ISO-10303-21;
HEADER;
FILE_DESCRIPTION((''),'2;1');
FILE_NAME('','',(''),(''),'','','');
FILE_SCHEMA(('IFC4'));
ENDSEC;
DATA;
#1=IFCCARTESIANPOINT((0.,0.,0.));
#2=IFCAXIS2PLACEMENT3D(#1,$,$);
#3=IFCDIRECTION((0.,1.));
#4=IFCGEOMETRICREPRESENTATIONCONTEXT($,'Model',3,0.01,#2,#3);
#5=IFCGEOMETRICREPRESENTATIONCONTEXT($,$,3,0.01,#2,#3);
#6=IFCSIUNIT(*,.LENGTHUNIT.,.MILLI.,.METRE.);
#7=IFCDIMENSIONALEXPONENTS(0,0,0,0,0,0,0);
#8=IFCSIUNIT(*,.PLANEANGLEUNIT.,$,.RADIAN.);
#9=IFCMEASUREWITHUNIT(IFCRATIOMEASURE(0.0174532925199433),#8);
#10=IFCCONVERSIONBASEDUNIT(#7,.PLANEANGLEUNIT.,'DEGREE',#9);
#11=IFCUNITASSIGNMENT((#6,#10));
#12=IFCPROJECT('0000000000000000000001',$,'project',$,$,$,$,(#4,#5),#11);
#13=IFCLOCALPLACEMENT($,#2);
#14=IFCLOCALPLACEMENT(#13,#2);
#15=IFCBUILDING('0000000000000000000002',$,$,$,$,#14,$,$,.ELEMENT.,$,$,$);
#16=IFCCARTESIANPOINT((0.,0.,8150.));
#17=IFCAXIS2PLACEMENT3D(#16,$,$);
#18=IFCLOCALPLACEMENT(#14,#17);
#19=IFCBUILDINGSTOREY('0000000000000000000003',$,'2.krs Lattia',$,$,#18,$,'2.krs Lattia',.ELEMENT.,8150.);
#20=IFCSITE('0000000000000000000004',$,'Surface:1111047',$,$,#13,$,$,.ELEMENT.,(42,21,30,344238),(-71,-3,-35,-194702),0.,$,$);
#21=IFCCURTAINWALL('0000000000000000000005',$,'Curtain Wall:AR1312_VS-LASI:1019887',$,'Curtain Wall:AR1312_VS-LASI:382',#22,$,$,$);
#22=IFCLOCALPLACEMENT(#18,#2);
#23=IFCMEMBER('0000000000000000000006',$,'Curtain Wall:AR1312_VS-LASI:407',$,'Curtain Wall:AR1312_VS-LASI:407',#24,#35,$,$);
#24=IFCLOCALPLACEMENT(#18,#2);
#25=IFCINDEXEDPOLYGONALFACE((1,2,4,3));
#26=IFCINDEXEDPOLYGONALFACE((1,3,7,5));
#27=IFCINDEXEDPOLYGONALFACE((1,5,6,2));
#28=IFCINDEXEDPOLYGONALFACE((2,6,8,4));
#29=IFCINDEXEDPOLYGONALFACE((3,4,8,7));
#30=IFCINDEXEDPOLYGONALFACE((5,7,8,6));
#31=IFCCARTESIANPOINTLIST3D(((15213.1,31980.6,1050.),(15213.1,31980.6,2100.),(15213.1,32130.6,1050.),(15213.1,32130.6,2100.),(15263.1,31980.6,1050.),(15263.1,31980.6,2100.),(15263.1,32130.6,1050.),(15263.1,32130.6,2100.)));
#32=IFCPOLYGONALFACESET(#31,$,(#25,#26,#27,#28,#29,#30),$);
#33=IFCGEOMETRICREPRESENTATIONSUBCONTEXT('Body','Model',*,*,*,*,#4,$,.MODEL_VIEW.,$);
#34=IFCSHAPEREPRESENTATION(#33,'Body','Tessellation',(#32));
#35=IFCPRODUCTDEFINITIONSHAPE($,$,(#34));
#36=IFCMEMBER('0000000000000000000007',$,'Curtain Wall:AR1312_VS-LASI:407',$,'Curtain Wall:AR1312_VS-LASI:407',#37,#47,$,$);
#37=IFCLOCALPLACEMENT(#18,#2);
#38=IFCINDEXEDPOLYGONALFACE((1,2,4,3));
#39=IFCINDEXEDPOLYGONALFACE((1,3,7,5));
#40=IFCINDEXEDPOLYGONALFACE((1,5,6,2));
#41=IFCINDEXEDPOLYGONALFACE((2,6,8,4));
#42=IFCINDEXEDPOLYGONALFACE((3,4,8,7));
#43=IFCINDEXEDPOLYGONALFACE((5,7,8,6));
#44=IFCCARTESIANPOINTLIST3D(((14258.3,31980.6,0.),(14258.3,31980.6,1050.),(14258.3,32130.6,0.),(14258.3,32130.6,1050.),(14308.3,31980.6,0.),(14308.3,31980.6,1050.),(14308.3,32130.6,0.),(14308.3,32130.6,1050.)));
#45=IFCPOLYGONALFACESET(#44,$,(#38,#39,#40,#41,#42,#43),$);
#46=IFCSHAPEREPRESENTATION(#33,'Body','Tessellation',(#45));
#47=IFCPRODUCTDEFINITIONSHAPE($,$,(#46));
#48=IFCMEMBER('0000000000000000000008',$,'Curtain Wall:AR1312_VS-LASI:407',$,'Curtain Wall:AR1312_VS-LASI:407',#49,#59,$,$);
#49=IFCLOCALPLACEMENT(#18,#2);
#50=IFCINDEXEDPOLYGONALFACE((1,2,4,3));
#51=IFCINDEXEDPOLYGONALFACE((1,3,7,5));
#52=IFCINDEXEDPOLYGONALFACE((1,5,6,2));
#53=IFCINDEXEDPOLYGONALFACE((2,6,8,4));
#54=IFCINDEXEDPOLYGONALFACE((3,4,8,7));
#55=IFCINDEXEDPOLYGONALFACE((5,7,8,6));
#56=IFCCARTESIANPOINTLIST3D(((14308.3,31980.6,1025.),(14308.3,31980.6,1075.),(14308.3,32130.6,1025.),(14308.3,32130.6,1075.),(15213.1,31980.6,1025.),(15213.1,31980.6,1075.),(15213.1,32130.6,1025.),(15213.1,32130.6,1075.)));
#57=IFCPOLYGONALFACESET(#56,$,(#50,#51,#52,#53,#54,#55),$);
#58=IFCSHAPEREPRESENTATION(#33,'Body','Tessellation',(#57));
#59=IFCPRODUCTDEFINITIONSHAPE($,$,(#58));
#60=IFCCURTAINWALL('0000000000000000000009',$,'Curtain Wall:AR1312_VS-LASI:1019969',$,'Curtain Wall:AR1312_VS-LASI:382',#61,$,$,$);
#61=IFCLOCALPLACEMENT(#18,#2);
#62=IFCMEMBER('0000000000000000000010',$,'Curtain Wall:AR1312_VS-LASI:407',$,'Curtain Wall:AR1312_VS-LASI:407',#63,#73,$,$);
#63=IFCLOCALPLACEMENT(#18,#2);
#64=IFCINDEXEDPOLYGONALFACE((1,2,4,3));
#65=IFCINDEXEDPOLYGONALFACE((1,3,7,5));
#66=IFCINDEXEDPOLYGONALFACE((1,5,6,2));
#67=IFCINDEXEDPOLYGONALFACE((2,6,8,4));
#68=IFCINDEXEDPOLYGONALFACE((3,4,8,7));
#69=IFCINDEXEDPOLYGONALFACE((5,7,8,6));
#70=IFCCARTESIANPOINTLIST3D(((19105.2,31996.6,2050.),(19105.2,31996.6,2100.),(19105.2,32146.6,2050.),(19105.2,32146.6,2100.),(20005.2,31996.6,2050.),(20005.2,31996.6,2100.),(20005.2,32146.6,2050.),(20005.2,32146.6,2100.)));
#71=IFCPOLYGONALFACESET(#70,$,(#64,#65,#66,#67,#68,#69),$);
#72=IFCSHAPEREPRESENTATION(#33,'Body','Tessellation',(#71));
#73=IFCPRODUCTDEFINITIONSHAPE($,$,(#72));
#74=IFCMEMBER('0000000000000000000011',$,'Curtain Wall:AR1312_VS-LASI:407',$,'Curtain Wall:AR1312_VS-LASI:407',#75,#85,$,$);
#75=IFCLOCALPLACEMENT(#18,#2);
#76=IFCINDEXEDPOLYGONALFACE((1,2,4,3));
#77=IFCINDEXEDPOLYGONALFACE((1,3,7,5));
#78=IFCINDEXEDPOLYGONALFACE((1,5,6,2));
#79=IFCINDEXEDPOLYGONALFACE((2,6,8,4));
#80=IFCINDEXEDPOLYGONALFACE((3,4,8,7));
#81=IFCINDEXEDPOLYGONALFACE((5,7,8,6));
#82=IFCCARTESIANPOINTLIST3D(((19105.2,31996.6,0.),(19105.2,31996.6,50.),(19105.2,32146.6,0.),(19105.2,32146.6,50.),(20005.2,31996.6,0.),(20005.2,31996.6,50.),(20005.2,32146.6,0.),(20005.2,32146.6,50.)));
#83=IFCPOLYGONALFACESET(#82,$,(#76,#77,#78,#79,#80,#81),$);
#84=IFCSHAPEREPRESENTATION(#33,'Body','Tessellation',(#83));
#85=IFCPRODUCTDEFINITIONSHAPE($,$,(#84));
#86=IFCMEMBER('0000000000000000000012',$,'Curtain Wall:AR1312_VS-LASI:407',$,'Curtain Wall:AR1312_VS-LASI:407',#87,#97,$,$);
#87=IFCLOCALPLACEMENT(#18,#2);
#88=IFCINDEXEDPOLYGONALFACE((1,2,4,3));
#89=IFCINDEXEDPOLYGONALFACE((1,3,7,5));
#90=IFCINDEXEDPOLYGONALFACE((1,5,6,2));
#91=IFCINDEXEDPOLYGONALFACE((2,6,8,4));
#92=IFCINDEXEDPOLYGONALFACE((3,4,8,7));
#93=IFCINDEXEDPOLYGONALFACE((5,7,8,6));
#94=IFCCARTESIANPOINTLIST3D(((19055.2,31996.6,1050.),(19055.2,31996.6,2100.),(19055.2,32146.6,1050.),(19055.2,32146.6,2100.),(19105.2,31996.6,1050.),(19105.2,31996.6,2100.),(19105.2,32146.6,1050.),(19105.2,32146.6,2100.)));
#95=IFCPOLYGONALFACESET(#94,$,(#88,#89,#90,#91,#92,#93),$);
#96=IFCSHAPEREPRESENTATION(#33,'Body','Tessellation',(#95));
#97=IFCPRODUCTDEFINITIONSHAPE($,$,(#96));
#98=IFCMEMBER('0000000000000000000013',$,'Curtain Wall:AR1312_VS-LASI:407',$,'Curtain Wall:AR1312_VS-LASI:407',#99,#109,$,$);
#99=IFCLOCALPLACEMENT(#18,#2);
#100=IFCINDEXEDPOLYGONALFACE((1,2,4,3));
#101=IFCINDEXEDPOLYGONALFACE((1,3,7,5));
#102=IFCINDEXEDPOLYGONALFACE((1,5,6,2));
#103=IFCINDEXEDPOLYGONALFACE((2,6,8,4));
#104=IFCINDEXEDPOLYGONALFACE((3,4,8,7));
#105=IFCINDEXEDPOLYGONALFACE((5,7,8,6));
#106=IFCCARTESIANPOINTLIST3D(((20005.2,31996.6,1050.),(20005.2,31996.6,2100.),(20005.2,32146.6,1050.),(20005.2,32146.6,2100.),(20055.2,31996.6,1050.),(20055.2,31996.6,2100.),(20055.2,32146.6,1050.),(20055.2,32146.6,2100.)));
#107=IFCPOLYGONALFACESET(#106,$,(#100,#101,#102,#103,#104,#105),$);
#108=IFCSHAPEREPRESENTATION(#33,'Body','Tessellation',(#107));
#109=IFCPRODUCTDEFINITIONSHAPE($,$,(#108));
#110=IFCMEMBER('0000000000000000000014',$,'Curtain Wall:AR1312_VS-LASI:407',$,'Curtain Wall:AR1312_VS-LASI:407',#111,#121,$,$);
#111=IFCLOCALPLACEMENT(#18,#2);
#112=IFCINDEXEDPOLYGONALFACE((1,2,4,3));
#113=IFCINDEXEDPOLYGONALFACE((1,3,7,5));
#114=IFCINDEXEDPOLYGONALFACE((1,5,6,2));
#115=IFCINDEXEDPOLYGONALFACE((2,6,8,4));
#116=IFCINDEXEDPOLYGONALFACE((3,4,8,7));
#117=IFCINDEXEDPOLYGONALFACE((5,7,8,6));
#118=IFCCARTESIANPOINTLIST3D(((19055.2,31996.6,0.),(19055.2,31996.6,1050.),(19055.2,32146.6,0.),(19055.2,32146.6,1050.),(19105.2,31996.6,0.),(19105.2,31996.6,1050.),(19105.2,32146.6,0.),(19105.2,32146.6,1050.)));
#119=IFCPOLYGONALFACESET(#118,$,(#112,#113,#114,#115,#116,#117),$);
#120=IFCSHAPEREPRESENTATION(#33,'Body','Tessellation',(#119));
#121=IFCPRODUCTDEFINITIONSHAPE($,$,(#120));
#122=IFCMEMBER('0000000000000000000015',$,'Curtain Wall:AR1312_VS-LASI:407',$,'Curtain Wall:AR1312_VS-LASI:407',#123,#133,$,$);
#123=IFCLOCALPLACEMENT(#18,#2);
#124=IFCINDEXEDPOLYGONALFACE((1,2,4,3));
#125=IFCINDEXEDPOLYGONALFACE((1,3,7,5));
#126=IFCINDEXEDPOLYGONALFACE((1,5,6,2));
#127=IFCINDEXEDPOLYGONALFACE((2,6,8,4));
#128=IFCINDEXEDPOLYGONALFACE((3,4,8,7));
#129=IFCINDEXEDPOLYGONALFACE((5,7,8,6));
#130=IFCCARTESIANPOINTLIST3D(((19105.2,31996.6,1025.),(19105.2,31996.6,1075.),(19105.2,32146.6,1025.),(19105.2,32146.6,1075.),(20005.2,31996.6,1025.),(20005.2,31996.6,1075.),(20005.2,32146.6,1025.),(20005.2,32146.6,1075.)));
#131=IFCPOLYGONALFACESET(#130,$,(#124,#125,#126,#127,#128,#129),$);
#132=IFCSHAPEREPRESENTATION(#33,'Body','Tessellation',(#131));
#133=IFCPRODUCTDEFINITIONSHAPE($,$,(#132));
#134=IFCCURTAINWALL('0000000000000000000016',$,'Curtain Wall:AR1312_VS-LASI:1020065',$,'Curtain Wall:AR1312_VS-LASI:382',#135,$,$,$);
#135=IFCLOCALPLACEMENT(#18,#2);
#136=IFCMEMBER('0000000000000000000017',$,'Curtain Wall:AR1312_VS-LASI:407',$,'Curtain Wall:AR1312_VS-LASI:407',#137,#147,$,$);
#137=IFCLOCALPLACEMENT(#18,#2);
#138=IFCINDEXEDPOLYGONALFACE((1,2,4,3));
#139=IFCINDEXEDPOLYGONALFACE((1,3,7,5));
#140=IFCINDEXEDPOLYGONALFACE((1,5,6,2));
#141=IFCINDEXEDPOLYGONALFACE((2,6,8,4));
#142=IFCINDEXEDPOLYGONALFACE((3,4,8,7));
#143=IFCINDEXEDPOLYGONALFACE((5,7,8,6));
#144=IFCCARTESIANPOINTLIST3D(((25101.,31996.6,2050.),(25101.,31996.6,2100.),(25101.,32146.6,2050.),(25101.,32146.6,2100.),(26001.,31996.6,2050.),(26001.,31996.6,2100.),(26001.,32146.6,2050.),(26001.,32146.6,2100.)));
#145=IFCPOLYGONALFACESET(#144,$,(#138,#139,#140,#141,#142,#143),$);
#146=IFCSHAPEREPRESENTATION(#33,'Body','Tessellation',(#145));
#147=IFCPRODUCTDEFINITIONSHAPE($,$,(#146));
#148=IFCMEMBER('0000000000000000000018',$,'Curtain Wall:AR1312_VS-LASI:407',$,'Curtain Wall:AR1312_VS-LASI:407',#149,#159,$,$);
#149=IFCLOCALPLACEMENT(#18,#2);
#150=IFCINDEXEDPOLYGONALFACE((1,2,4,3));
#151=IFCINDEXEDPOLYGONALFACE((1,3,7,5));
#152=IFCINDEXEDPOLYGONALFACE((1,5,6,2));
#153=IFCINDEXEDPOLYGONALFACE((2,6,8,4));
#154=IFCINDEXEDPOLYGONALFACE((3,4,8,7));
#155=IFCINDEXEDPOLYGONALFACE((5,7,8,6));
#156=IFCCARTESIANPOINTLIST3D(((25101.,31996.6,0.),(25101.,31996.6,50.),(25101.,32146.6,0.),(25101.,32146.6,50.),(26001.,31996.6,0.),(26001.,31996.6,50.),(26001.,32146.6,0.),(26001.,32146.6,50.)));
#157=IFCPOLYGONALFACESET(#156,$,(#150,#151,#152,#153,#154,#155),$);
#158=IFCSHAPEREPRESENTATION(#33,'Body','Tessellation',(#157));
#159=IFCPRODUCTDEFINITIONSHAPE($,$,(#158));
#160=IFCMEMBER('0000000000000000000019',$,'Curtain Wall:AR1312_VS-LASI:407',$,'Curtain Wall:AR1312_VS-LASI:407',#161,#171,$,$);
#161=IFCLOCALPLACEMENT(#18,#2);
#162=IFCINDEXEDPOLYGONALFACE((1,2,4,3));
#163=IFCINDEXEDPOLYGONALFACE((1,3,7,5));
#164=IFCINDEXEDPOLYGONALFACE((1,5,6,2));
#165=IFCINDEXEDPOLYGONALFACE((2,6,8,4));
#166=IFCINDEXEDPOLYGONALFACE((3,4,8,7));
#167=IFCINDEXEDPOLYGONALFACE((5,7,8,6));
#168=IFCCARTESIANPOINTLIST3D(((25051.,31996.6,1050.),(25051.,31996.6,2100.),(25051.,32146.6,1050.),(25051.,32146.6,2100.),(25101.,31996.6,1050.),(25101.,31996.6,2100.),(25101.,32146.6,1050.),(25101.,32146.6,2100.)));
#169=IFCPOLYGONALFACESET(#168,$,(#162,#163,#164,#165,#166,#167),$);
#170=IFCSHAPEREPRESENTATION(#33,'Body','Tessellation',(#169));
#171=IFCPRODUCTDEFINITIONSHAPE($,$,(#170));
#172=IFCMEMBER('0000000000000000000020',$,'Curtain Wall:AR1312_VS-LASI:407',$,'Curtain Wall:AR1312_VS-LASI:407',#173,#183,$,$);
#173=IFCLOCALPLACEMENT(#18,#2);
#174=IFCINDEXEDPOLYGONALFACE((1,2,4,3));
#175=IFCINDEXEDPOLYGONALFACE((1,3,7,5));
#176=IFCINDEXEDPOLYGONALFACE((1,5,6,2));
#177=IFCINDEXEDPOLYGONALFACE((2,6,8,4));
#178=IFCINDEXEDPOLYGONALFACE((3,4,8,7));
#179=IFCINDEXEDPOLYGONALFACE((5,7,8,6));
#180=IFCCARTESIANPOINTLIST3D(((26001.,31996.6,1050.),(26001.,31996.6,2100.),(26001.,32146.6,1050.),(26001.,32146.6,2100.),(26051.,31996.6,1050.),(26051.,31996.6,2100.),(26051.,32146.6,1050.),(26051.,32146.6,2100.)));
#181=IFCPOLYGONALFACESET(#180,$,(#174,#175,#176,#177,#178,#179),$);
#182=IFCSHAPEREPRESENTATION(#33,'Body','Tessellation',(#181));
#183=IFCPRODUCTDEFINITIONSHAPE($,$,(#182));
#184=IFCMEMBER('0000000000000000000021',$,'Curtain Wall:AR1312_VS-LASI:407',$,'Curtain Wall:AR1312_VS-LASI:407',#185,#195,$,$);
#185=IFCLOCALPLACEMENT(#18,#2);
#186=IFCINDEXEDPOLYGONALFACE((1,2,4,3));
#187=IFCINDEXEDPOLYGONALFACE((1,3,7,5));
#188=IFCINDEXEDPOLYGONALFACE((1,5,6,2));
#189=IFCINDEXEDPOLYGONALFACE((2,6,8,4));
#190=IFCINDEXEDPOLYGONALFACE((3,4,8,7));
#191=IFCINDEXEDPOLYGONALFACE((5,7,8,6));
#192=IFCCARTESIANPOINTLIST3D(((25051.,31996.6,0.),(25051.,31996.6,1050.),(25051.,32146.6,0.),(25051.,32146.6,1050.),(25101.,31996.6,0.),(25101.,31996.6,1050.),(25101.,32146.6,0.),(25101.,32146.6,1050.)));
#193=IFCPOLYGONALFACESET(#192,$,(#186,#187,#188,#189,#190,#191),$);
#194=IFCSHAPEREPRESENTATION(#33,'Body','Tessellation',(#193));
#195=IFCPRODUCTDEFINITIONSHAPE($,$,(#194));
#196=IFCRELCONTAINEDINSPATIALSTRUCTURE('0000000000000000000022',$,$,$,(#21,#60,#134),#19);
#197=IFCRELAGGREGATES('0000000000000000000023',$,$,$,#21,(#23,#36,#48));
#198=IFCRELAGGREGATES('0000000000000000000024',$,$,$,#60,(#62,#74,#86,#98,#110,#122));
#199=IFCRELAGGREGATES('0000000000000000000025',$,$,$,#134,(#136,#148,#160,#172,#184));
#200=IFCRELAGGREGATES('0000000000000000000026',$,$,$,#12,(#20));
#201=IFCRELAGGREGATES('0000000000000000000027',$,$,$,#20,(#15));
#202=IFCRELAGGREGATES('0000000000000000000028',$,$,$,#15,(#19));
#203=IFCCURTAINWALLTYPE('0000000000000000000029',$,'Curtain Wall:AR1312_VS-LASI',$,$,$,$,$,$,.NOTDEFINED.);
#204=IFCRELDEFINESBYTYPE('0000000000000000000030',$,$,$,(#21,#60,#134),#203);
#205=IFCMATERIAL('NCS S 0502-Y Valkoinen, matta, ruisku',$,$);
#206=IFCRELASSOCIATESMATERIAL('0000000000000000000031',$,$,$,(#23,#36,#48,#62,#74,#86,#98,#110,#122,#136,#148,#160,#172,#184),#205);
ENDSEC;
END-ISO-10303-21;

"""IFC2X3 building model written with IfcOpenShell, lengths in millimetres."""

from ifc_helpers import new_model, entity, si_unit, converted_unit, direction, frame, frame_2d, origin, place, context, subcontext, project, spatial, rectangle, extrude, material, type_object, element, aggregate, save


model = new_model("IFC2X3")

# Units and contexts
model_context = context("Model", 3, precision=0.01, world=origin(), true_north=direction((0.0, 1.0)))
context_of_model = context(None, 3, precision=0.01, world=origin(), true_north=direction((0.0, 1.0)))
body_context = subcontext(model_context, "Body", "Model", "MODEL_VIEW")
ifc_project = project(units=[si_unit("LENGTHUNIT", "METRE", prefix="MILLI"), converted_unit("PLANEANGLEUNIT", "DEGREE", entity("IfcRatioMeasure", 0.0174532925199433), si_unit("PLANEANGLEUNIT", "RADIAN"), dimensions=[0, 0, 0, 0, 0, 0, 0])], contexts=[model_context, context_of_model])

# Site, building, storey
site_placement = place(None, origin())
site = spatial("IfcSite", under=ifc_project, at=site_placement, Name="Surface:1111047", CompositionType="ELEMENT", RefLatitude=(42, 21, 30, 344238), RefLongitude=(-71, -3, -35, -194702), RefElevation=0.0)
building_placement = place(site_placement, origin())
building = spatial("IfcBuilding", under=site, at=building_placement, CompositionType="ELEMENT")
storey_placement = place(building_placement, frame((0.0, 0.0, 8150.0)))
storey = spatial("IfcBuildingStorey", under=building, at=storey_placement, Name="2.krs Lattia", LongName="2.krs Lattia", CompositionType="ELEMENT", Elevation=8150.0)

# Curtain walls, members
curtain_wall_type = type_object("IfcCurtainWallType", Name="Curtain Wall:AR1312_VS-LASI", PredefinedType="NOTDEFINED")
curtain_wall_1_placement = place(storey_placement, frame((0.0, 0.0, -8150.0)))
curtain_wall_1 = element("IfcCurtainWall", 1, at=curtain_wall_1_placement, inside=storey, type_object=curtain_wall_type, Name="Curtain Wall:AR1312_VS-LASI:1019887", ObjectType="Curtain Wall:AR1312_VS-LASI:382")
ifc_material_1 = material(Name="NCS S 0502-Y Valkoinen, matta, ruisku")
member_1_placement = place(curtain_wall_1_placement, frame((0.0, 0.0, 8150.0)))
member_1 = element("IfcMember", 2, at=member_1_placement, material=ifc_material_1, Name="Curtain Wall:AR1312_VS-LASI:407", ObjectType="Curtain Wall:AR1312_VS-LASI:407", context=body_context, shape_type="SweptSolid", body=[
    extrude(rectangle(XDim=50.0, YDim=150.0, at=frame_2d((0.0, 0.0), x_axis=(1.0, 0.0))), frame((15238.1, 32055.6, 1050.0), z_axis=(0.0, 0.0, 1.0), x_axis=(-1.0, 0.0, 0.0)), (0.0, 0.0, 1.0), 1050.0),
])
member_2_placement = place(curtain_wall_1_placement, frame((0.0, 0.0, 8150.0)))
member_2 = element("IfcMember", 3, at=member_2_placement, material=ifc_material_1, Name="Curtain Wall:AR1312_VS-LASI:407", ObjectType="Curtain Wall:AR1312_VS-LASI:407", context=body_context, shape_type="SweptSolid", body=[
    extrude(rectangle(XDim=50.0, YDim=150.0, at=frame_2d((0.0, 0.0), x_axis=(1.0, 0.0))), frame((14283.3, 32055.6, 1050.0), z_axis=(0.0, 0.0, -1.0), x_axis=(-1.0, 0.0, 0.0)), (0.0, 0.0, 1.0), 1050.0),
])
member_3_placement = place(curtain_wall_1_placement, frame((0.0, 0.0, 8150.0)))
member_3 = element("IfcMember", 4, at=member_3_placement, material=ifc_material_1, Name="Curtain Wall:AR1312_VS-LASI:407", ObjectType="Curtain Wall:AR1312_VS-LASI:407", context=body_context, shape_type="SweptSolid", body=[
    extrude(rectangle(XDim=50.0, YDim=150.0, at=frame_2d((0.0, 0.0), x_axis=(1.0, 0.0))), frame((15213.1, 32055.6, 1050.0), z_axis=(-1.0, 0.0, 0.0), x_axis=(0.0, 0.0, -1.0)), (0.0, 0.0, 1.0), 904.8),
])
aggregate(curtain_wall_1, [member_1, member_2, member_3])
curtain_wall_2_placement = place(storey_placement, frame((0.0, 0.0, -8150.0)))
curtain_wall_2 = element("IfcCurtainWall", 5, at=curtain_wall_2_placement, inside=storey, type_object=curtain_wall_type, Name="Curtain Wall:AR1312_VS-LASI:1019969", ObjectType="Curtain Wall:AR1312_VS-LASI:382")
member_4_placement = place(curtain_wall_2_placement, frame((0.0, 0.0, 8150.0)))
member_4 = element("IfcMember", 6, at=member_4_placement, material=ifc_material_1, Name="Curtain Wall:AR1312_VS-LASI:407", ObjectType="Curtain Wall:AR1312_VS-LASI:407", context=body_context, shape_type="SweptSolid", body=[
    extrude(rectangle(XDim=50.0, YDim=150.0, at=frame_2d((0.0, 0.0), x_axis=(1.0, 0.0))), frame((20005.2, 32071.6, 2075.0), z_axis=(-1.0, 0.0, 0.0), x_axis=(0.0, 0.0, -1.0)), (0.0, 0.0, 1.0), 900.0),
])
member_5_placement = place(curtain_wall_2_placement, frame((0.0, 0.0, 8150.0)))
member_5 = element("IfcMember", 7, at=member_5_placement, material=ifc_material_1, Name="Curtain Wall:AR1312_VS-LASI:407", ObjectType="Curtain Wall:AR1312_VS-LASI:407", context=body_context, shape_type="SweptSolid", body=[
    extrude(rectangle(XDim=50.0, YDim=150.0, at=frame_2d((0.0, 0.0), x_axis=(1.0, 0.0))), frame((19105.2, 32071.6, 25.0), z_axis=(1.0, 0.0, 0.0), x_axis=(0.0, 0.0, -1.0)), (0.0, 0.0, 1.0), 900.0),
])
member_6_placement = place(curtain_wall_2_placement, frame((0.0, 0.0, 8150.0)))
member_6 = element("IfcMember", 8, at=member_6_placement, material=ifc_material_1, Name="Curtain Wall:AR1312_VS-LASI:407", ObjectType="Curtain Wall:AR1312_VS-LASI:407", context=body_context, shape_type="SweptSolid", body=[
    extrude(rectangle(XDim=50.0, YDim=150.0, at=frame_2d((0.0, 0.0), x_axis=(1.0, 0.0))), frame((19080.2, 32071.6, 2100.0), z_axis=(0.0, 0.0, -1.0), x_axis=(-1.0, 0.0, 0.0)), (0.0, 0.0, 1.0), 1050.0),
])
member_7_placement = place(curtain_wall_2_placement, frame((0.0, 0.0, 8150.0)))
member_7 = element("IfcMember", 9, at=member_7_placement, material=ifc_material_1, Name="Curtain Wall:AR1312_VS-LASI:407", ObjectType="Curtain Wall:AR1312_VS-LASI:407", context=body_context, shape_type="SweptSolid", body=[
    extrude(rectangle(XDim=50.0, YDim=150.0, at=frame_2d((0.0, 0.0), x_axis=(1.0, 0.0))), frame((20030.2, 32071.6, 1050.0), z_axis=(0.0, 0.0, 1.0), x_axis=(-1.0, 0.0, 0.0)), (0.0, 0.0, 1.0), 1050.0),
])
member_8_placement = place(curtain_wall_2_placement, frame((0.0, 0.0, 8150.0)))
member_8 = element("IfcMember", 10, at=member_8_placement, material=ifc_material_1, Name="Curtain Wall:AR1312_VS-LASI:407", ObjectType="Curtain Wall:AR1312_VS-LASI:407", context=body_context, shape_type="SweptSolid", body=[
    extrude(rectangle(XDim=50.0, YDim=150.0, at=frame_2d((0.0, 0.0), x_axis=(1.0, 0.0))), frame((19080.2, 32071.6, 1050.0), z_axis=(0.0, 0.0, -1.0), x_axis=(-1.0, 0.0, 0.0)), (0.0, 0.0, 1.0), 1050.0),
])
member_9_placement = place(curtain_wall_2_placement, frame((0.0, 0.0, 8150.0)))
member_9 = element("IfcMember", 11, at=member_9_placement, material=ifc_material_1, Name="Curtain Wall:AR1312_VS-LASI:407", ObjectType="Curtain Wall:AR1312_VS-LASI:407", context=body_context, shape_type="SweptSolid", body=[
    extrude(rectangle(XDim=50.0, YDim=150.0, at=frame_2d((0.0, 0.0), x_axis=(1.0, 0.0))), frame((20005.2, 32071.6, 1050.0), z_axis=(-1.0, 0.0, 0.0), x_axis=(0.0, 0.0, -1.0)), (0.0, 0.0, 1.0), 900.0),
])
aggregate(curtain_wall_2, [member_4, member_5, member_6, member_7, member_8, member_9])
curtain_wall_3_placement = place(storey_placement, frame((0.0, 0.0, -8150.0)))
curtain_wall_3 = element("IfcCurtainWall", 12, at=curtain_wall_3_placement, inside=storey, type_object=curtain_wall_type, Name="Curtain Wall:AR1312_VS-LASI:1020065", ObjectType="Curtain Wall:AR1312_VS-LASI:382")
member_10_placement = place(curtain_wall_3_placement, frame((0.0, 0.0, 8150.0)))
member_10 = element("IfcMember", 13, at=member_10_placement, material=ifc_material_1, Name="Curtain Wall:AR1312_VS-LASI:407", ObjectType="Curtain Wall:AR1312_VS-LASI:407", context=body_context, shape_type="SweptSolid", body=[
    extrude(rectangle(XDim=50.0, YDim=150.0, at=frame_2d((0.0, 0.0), x_axis=(1.0, 0.0))), frame((26001.0, 32071.6, 2075.0), z_axis=(-1.0, 0.0, 0.0), x_axis=(0.0, 0.0, -1.0)), (0.0, 0.0, 1.0), 900.0),
])
member_11_placement = place(curtain_wall_3_placement, frame((0.0, 0.0, 8150.0)))
member_11 = element("IfcMember", 14, at=member_11_placement, material=ifc_material_1, Name="Curtain Wall:AR1312_VS-LASI:407", ObjectType="Curtain Wall:AR1312_VS-LASI:407", context=body_context, shape_type="SweptSolid", body=[
    extrude(rectangle(XDim=50.0, YDim=150.0, at=frame_2d((0.0, 0.0), x_axis=(1.0, 0.0))), frame((25101.0, 32071.6, 25.0), z_axis=(1.0, 0.0, 0.0), x_axis=(0.0, 0.0, -1.0)), (0.0, 0.0, 1.0), 900.0),
])
member_12_placement = place(curtain_wall_3_placement, frame((0.0, 0.0, 8150.0)))
member_12 = element("IfcMember", 15, at=member_12_placement, material=ifc_material_1, Name="Curtain Wall:AR1312_VS-LASI:407", ObjectType="Curtain Wall:AR1312_VS-LASI:407", context=body_context, shape_type="SweptSolid", body=[
    extrude(rectangle(XDim=50.0, YDim=150.0, at=frame_2d((0.0, 0.0), x_axis=(1.0, 0.0))), frame((25076.0, 32071.6, 2100.0), z_axis=(0.0, 0.0, -1.0), x_axis=(-1.0, 0.0, 0.0)), (0.0, 0.0, 1.0), 1050.0),
])
member_13_placement = place(curtain_wall_3_placement, frame((0.0, 0.0, 8150.0)))
member_13 = element("IfcMember", 16, at=member_13_placement, material=ifc_material_1, Name="Curtain Wall:AR1312_VS-LASI:407", ObjectType="Curtain Wall:AR1312_VS-LASI:407", context=body_context, shape_type="SweptSolid", body=[
    extrude(rectangle(XDim=50.0, YDim=150.0, at=frame_2d((0.0, 0.0), x_axis=(1.0, 0.0))), frame((26026.0, 32071.6, 1050.0), z_axis=(0.0, 0.0, 1.0), x_axis=(-1.0, 0.0, 0.0)), (0.0, 0.0, 1.0), 1050.0),
])
member_14_placement = place(curtain_wall_3_placement, frame((0.0, 0.0, 8150.0)))
member_14 = element("IfcMember", 17, at=member_14_placement, material=ifc_material_1, Name="Curtain Wall:AR1312_VS-LASI:407", ObjectType="Curtain Wall:AR1312_VS-LASI:407", context=body_context, shape_type="SweptSolid", body=[
    extrude(rectangle(XDim=50.0, YDim=150.0, at=frame_2d((0.0, 0.0), x_axis=(1.0, 0.0))), frame((25076.0, 32071.6, 1050.0), z_axis=(0.0, 0.0, -1.0), x_axis=(-1.0, 0.0, 0.0)), (0.0, 0.0, 1.0), 1050.0),
])
aggregate(curtain_wall_3, [member_10, member_11, member_12, member_13, member_14])

save(model, "model.ifc")
